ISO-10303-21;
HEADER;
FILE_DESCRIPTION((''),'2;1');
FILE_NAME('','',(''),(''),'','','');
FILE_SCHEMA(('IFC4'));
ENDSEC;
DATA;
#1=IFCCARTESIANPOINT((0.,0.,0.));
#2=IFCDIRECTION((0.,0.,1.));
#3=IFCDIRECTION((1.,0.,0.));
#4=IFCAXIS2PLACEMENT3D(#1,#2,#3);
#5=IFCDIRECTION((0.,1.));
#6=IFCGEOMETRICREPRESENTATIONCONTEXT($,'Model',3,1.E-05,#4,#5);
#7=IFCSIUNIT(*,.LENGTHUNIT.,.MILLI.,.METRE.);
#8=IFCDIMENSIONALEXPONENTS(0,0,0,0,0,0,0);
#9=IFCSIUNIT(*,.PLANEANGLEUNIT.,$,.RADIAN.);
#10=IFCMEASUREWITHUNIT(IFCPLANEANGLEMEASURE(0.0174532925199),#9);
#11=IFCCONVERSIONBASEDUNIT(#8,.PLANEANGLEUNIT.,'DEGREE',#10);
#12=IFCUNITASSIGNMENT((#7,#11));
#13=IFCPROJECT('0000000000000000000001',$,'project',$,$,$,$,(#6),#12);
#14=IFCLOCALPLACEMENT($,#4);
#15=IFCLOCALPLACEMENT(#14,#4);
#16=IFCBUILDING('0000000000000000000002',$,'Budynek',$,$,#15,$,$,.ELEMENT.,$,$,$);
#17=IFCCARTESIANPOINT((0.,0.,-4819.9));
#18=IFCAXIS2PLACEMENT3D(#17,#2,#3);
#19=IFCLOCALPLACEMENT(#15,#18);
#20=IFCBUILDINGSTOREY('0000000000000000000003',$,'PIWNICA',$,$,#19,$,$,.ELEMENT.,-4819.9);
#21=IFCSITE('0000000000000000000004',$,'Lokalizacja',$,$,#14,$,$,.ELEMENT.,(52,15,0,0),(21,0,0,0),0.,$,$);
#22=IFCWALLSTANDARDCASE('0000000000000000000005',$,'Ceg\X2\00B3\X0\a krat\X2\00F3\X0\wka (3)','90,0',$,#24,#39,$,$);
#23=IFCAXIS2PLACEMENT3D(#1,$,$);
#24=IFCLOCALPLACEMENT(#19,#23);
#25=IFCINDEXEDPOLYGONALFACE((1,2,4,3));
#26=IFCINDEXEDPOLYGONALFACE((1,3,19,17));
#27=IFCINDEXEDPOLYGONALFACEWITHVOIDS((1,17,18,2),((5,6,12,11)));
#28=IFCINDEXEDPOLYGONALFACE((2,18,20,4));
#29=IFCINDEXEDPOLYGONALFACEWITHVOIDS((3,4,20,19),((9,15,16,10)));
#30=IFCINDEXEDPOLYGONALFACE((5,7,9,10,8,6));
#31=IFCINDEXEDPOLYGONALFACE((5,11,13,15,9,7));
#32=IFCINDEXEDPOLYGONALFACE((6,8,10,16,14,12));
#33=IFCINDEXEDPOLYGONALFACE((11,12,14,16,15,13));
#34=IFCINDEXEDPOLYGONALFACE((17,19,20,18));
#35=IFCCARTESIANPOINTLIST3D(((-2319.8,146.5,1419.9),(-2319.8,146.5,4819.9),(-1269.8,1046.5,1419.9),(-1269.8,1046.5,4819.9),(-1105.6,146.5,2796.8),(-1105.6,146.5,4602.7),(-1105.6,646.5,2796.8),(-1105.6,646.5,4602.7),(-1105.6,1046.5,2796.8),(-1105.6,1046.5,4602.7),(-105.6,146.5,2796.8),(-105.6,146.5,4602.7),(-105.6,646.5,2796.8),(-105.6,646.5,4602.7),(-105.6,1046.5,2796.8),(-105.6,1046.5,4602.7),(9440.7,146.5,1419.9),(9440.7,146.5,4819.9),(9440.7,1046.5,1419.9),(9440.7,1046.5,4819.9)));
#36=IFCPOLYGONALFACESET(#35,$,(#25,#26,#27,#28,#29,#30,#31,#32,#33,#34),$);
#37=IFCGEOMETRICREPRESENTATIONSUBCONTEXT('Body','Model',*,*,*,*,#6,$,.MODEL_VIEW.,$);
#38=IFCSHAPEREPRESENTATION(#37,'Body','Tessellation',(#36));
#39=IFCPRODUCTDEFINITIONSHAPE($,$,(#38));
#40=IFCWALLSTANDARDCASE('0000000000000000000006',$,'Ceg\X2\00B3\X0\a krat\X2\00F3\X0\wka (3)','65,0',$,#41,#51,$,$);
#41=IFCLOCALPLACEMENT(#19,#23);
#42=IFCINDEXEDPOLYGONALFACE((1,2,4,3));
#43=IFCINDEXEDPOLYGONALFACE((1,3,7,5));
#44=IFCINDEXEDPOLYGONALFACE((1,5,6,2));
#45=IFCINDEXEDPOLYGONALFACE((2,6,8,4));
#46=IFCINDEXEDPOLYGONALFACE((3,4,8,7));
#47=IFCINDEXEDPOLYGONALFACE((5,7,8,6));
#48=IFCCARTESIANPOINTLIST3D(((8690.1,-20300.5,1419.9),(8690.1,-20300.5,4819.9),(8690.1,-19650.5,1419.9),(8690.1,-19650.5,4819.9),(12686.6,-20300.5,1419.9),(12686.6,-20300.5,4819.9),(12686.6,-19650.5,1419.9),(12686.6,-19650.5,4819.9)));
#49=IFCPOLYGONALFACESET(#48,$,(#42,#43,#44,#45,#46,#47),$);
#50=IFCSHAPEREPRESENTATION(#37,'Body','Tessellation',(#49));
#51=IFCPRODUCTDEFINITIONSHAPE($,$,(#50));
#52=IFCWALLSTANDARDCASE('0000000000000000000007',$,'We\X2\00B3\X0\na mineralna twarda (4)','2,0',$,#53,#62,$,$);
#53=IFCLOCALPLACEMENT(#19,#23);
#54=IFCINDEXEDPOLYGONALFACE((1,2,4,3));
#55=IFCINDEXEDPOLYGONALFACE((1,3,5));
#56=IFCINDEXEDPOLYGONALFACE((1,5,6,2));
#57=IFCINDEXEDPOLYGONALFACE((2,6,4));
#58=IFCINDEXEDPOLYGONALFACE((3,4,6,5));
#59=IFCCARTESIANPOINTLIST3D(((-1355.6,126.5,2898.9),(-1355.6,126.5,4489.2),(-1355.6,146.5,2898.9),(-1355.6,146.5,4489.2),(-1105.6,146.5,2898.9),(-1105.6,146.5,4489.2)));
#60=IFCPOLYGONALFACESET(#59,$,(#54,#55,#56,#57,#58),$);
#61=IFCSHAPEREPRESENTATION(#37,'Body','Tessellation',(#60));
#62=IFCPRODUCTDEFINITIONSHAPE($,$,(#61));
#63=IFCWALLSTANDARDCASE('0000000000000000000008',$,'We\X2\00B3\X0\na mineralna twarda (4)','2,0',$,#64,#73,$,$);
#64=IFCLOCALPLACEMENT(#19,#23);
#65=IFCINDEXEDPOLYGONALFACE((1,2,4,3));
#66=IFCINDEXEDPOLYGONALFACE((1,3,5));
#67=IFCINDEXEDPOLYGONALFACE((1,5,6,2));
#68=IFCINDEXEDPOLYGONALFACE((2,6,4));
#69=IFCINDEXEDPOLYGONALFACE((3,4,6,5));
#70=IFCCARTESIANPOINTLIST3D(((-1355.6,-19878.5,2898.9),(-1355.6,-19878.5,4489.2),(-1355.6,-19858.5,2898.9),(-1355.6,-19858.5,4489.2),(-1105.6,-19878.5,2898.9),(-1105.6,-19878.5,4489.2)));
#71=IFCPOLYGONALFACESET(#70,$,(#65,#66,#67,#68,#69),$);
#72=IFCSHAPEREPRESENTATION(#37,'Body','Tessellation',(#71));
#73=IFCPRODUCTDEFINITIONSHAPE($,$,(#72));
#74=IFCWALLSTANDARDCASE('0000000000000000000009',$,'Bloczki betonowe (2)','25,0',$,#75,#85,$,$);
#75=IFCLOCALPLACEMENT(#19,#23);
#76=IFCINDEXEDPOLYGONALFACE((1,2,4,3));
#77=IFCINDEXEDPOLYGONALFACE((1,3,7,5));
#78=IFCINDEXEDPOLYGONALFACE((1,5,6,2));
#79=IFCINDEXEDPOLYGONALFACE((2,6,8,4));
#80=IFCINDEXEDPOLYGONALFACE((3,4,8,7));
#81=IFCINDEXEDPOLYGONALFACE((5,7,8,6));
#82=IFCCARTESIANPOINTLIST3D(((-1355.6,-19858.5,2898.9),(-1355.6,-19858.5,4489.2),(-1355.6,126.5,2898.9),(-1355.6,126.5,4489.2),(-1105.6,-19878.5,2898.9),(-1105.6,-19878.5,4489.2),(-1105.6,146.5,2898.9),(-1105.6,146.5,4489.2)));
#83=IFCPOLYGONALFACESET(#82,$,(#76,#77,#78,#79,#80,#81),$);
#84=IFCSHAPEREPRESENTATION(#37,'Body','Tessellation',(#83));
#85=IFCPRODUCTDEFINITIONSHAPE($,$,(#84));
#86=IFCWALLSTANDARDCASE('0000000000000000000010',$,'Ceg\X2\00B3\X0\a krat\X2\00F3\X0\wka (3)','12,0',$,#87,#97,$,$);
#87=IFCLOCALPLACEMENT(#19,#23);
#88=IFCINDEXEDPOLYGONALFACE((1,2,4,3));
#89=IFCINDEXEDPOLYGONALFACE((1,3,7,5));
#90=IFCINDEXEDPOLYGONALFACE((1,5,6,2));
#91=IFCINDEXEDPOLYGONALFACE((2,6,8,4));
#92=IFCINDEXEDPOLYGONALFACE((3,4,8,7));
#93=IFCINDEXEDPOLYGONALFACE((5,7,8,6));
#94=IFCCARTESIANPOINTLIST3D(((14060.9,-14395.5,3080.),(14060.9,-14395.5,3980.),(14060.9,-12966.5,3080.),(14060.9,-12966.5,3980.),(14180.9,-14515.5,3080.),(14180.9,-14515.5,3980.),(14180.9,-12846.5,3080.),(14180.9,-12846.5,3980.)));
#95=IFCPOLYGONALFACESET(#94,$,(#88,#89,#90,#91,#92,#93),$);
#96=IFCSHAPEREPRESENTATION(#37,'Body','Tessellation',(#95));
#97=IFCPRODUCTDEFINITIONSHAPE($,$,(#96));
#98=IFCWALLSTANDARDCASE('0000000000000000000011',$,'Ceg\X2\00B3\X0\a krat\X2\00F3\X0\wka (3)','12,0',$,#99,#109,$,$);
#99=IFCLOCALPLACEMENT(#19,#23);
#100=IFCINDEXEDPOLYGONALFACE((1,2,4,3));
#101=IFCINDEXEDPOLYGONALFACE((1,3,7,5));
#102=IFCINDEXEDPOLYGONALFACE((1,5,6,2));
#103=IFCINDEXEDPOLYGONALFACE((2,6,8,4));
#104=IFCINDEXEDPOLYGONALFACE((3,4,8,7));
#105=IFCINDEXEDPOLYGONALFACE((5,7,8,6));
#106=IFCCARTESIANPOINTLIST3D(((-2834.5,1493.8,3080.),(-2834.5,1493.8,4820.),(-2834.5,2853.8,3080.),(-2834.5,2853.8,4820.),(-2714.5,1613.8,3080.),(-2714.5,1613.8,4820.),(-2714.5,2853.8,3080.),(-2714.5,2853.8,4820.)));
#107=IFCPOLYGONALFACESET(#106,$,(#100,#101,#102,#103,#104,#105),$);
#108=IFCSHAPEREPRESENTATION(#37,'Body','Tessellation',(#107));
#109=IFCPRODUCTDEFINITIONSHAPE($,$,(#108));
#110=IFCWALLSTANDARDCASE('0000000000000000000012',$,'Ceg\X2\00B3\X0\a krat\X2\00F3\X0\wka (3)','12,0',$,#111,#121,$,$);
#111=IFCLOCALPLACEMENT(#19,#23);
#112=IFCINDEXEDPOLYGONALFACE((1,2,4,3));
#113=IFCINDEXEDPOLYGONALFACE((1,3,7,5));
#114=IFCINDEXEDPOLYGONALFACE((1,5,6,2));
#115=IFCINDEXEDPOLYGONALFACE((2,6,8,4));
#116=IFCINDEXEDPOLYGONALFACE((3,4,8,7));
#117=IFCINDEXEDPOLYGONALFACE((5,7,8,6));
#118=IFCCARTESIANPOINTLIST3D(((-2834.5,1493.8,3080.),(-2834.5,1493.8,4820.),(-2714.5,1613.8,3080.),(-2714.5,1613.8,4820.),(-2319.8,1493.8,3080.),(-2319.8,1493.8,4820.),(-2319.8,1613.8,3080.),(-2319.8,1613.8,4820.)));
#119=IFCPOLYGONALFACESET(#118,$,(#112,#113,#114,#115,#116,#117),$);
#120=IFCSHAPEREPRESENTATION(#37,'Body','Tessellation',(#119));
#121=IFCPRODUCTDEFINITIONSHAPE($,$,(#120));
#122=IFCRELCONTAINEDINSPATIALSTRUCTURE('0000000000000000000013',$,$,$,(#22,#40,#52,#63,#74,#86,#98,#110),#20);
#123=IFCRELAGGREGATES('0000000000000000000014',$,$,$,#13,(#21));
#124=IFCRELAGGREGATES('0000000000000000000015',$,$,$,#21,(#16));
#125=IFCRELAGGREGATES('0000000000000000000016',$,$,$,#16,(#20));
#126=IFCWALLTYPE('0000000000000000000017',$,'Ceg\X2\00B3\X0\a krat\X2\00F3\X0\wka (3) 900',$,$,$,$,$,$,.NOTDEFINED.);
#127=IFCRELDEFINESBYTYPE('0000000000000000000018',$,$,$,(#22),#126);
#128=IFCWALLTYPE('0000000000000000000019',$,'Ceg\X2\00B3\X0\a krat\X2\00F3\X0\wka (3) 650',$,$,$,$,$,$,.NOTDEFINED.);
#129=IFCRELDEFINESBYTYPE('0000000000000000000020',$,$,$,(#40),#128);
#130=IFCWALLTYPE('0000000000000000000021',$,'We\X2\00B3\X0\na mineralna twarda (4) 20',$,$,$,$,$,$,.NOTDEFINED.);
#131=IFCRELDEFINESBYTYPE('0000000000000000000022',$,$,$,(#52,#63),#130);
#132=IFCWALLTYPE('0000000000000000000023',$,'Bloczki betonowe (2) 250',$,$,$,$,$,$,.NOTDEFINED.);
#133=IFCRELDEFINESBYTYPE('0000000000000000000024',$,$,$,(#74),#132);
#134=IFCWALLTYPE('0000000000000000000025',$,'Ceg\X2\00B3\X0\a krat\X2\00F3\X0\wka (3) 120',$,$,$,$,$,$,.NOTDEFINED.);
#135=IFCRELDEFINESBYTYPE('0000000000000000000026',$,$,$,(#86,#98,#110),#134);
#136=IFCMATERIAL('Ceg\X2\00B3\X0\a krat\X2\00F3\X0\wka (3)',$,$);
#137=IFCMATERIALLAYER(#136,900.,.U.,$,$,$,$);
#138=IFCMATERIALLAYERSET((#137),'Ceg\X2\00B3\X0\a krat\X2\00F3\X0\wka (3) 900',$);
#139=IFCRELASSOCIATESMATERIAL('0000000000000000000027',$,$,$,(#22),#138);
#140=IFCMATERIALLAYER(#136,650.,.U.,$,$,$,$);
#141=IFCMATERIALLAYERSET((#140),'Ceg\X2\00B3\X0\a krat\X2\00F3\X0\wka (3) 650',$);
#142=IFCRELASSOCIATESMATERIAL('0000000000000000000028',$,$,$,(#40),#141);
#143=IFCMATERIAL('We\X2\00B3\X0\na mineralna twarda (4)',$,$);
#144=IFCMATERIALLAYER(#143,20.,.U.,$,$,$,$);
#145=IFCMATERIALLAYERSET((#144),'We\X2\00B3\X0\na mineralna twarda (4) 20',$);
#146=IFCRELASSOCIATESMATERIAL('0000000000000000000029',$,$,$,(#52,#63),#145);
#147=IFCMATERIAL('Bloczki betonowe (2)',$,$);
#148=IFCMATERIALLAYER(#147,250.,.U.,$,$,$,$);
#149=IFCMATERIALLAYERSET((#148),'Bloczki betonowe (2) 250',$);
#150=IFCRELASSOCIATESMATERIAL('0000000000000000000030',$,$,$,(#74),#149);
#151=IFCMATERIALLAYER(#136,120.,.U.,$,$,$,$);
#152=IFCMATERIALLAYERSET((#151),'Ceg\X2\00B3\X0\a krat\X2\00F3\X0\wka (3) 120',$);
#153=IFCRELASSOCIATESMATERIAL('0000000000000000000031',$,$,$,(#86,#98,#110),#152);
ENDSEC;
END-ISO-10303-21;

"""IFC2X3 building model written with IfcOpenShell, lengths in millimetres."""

from ifc_helpers import new_model, entity, si_unit, converted_unit, direction, frame, origin_with_axes, origin_2d_with_axis, place, context, subcontext, project, spatial, polyline, rectangle, outline, extrude, material, layer, layer_set, layer_usage, type_object, element, save


model = new_model("IFC2X3")

# Units and contexts
model_context = context("Model", 3, precision=1e-05, world=origin_with_axes(), true_north=direction((0.0, 1.0)))
body_context = subcontext(model_context, "Body", "Model", "MODEL_VIEW")
ifc_project = project(units=[si_unit("LENGTHUNIT", "METRE", prefix="MILLI"), converted_unit("PLANEANGLEUNIT", "DEGREE", entity("IfcPlaneAngleMeasure", 0.0174532925199), si_unit("PLANEANGLEUNIT", "RADIAN"), dimensions=[0, 0, 0, 0, 0, 0, 0])], contexts=[model_context])

# Site, building, storey
site_placement = place(None, origin_with_axes())
site = spatial("IfcSite", under=ifc_project, at=site_placement, Name="Lokalizacja", CompositionType="ELEMENT", RefLatitude=(52, 15, 0, 0), RefLongitude=(21, 0, 0, 0), RefElevation=0.0)
building_placement = place(site_placement, origin_with_axes())
building = spatial("IfcBuilding", under=site, at=building_placement, Name="Budynek", CompositionType="ELEMENT")
storey_placement = place(building_placement, frame((0.0, 0.0, -4819.9), z_axis=(0.0, 0.0, 1.0), x_axis=(1.0, 0.0, 0.0)))
storey = spatial("IfcBuildingStorey", under=building, at=storey_placement, Name="PIWNICA", CompositionType="ELEMENT", Elevation=-4819.9)

# Shared definitions
ifc_material_1 = material(Name="Bloczki betonowe (2)")

# Shared definitions
ifc_material_2 = material(Name="Ceg³a kratówka (3)")

# Wall, opening
ifc_layer_1 = layer(ifc_material_2, 900.0, ventilated="UNKNOWN")
ifc_layer_set_1 = layer_set([ifc_layer_1], Name="Ceg³a kratówka (3) 900")
ifc_layer_usage_1 = layer_usage(ifc_layer_set_1, "AXIS2", "POSITIVE", -200.0)
wall_type_1 = type_object("IfcWallType", Name="Ceg³a kratówka (3) 900", PredefinedType="NOTDEFINED")
wall_1_placement = place(storey_placement, frame((9440.7, 846.5, 1419.9), z_axis=(0.0, 0.0, 1.0), x_axis=(-1.0, 0.0, 0.0)))
wall_1 = element("IfcWallStandardCase", 1, at=wall_1_placement, inside=storey, type_object=wall_type_1, material=ifc_layer_usage_1, Name="Ceg³a kratówka (3)", Description="90,0", context=body_context, shape_type="SweptSolid", body=[
    extrude(outline(polyline([(0.0, -200.0), (10710.5, -200.0), (11760.5, 700.0), (0.0, 700.0), (0.0, -200.0)])), origin_with_axes(), (0.0, 0.0, 1.0), 3400.0),
])
opening_1_placement = place(wall_1_placement, frame((10046.2, 0.0, 1376.9), z_axis=(0.0, 0.0, 1.0), x_axis=(1.0, 0.0, 0.0)))
element("IfcOpeningElement", 2, at=opening_1_placement, cuts=wall_1, context=body_context, shape_type="SweptSolid", body=[
    extrude(rectangle(XDim=1000.0, YDim=1805.9, at=origin_2d_with_axis()), frame((0.0, 200.0, 902.9), z_axis=(0.0, -1.0, 0.0), x_axis=(1.0, 0.0, 0.0)), (0.0, 0.0, -1.0), 900.0),
    extrude(rectangle(XDim=1000.0, YDim=1805.9, at=origin_2d_with_axis()), frame((0.0, 200.0, 902.9), z_axis=(0.0, 1.0, 0.0), x_axis=(1.0, 0.0, 0.0)), (0.0, 0.0, -1.0), 900.0),
])

# Walls
ifc_layer_2 = layer(ifc_material_2, 650.0, ventilated="UNKNOWN")
ifc_layer_set_2 = layer_set([ifc_layer_2], Name="Ceg³a kratówka (3) 650")
ifc_layer_usage_2 = layer_usage(ifc_layer_set_2, "AXIS2", "POSITIVE", 0.0)
wall_type_2 = type_object("IfcWallType", Name="Ceg³a kratówka (3) 650", PredefinedType="NOTDEFINED")
wall_2_placement = place(storey_placement, frame((12686.6, -19650.5, 1419.9), z_axis=(0.0, 0.0, 1.0), x_axis=(-1.0, 0.0, 0.0)))
element("IfcWallStandardCase", 3, at=wall_2_placement, inside=storey, type_object=wall_type_2, material=ifc_layer_usage_2, Name="Ceg³a kratówka (3)", Description="65,0", context=body_context, shape_type="SweptSolid", body=[
    extrude(outline(polyline([(0.0, 0.0), (3996.4, 0.0), (3996.4, 650.0), (0.0, 650.0), (0.0, 0.0)])), origin_with_axes(), (0.0, 0.0, 1.0), 3400.0),
])
ifc_material_3 = material(Name="We³na mineralna twarda (4)")
ifc_layer_3 = layer(ifc_material_3, 20.0, ventilated="UNKNOWN")
ifc_layer_set_3 = layer_set([ifc_layer_3], Name="We³na mineralna twarda (4) 20")
ifc_layer_usage_3 = layer_usage(ifc_layer_set_3, "AXIS2", "NEGATIVE", 0.0)
wall_type_3 = type_object("IfcWallType", Name="We³na mineralna twarda (4) 20", PredefinedType="NOTDEFINED")
wall_3_placement = place(storey_placement, frame((-1105.6, 126.5, 2898.9), z_axis=(0.0, 0.0, 1.0), x_axis=(-1.0, 0.0, 0.0)))
element("IfcWallStandardCase", 4, at=wall_3_placement, inside=storey, type_object=wall_type_3, material=ifc_layer_usage_3, Name="We³na mineralna twarda (4)", Description="2,0", context=body_context, shape_type="SweptSolid", body=[
    extrude(outline(polyline([(0.0, -20.0), (250.0, -20.0), (250.0, 0.0), (0.0, -20.0)])), origin_with_axes(), (0.0, 0.0, 1.0), 1590.3),
])
ifc_layer_usage_4 = layer_usage(ifc_layer_set_3, "AXIS2", "NEGATIVE", 0.0)
wall_4_placement = place(storey_placement, frame((-1105.6, -19878.5, 2898.9), z_axis=(0.0, 0.0, 1.0), x_axis=(-1.0, 0.0, 0.0)))
element("IfcWallStandardCase", 5, at=wall_4_placement, inside=storey, type_object=wall_type_3, material=ifc_layer_usage_4, Name="We³na mineralna twarda (4)", Description="2,0", context=body_context, shape_type="SweptSolid", body=[
    extrude(outline(polyline([(250.0, -20.0), (250.0, 0.0), (0.0, 0.0), (250.0, -20.0)])), origin_with_axes(), (0.0, 0.0, 1.0), 1590.3),
])
ifc_layer_4 = layer(ifc_material_1, 250.0, ventilated="UNKNOWN")
ifc_layer_set_4 = layer_set([ifc_layer_4], Name="Bloczki betonowe (2) 250")
ifc_layer_usage_5 = layer_usage(ifc_layer_set_4, "AXIS2", "POSITIVE", 0.0)
wall_type_4 = type_object("IfcWallType", Name="Bloczki betonowe (2) 250", PredefinedType="NOTDEFINED")
wall_5_placement = place(storey_placement, frame((-1105.6, -19878.5, 2898.9), z_axis=(0.0, 0.0, 1.0), x_axis=(0.0, 1.0, 0.0)))
element("IfcWallStandardCase", 6, at=wall_5_placement, inside=storey, type_object=wall_type_4, material=ifc_layer_usage_5, Name="Bloczki betonowe (2)", Description="25,0", context=body_context, shape_type="SweptSolid", body=[
    extrude(outline(polyline([(0.0, 0.0), (20025.0, 0.0), (20005.0, 250.0), (20.0, 250.0), (0.0, 0.0)])), origin_with_axes(), (0.0, 0.0, 1.0), 1590.3),
])
ifc_layer_5 = layer(ifc_material_2, 120.0, ventilated="UNKNOWN")
ifc_layer_set_5 = layer_set([ifc_layer_5], Name="Ceg³a kratówka (3) 120")
ifc_layer_usage_6 = layer_usage(ifc_layer_set_5, "AXIS2", "NEGATIVE", 0.0)
wall_type_5 = type_object("IfcWallType", Name="Ceg³a kratówka (3) 120", PredefinedType="NOTDEFINED")
wall_6_placement = place(storey_placement, frame((14060.9, -14395.5, 3080.0), z_axis=(0.0, 0.0, 1.0), x_axis=(0.0, 1.0, 0.0)))
element("IfcWallStandardCase", 7, at=wall_6_placement, inside=storey, type_object=wall_type_5, material=ifc_layer_usage_6, Name="Ceg³a kratówka (3)", Description="12,0", context=body_context, shape_type="SweptSolid", body=[
    extrude(outline(polyline([(-120.0, -120.0), (1549.0, -120.0), (1429.0, 0.0), (0.0, 0.0), (-120.0, -120.0)])), origin_with_axes(), (0.0, 0.0, 1.0), 900.0),
])
ifc_layer_usage_7 = layer_usage(ifc_layer_set_5, "AXIS2", "POSITIVE", 0.0)
wall_7_placement = place(storey_placement, frame((-2714.5, 1613.8, 3080.0), z_axis=(0.0, 0.0, 1.0), x_axis=(0.0, 1.0, 0.0)))
element("IfcWallStandardCase", 8, at=wall_7_placement, inside=storey, type_object=wall_type_5, material=ifc_layer_usage_7, Name="Ceg³a kratówka (3)", Description="12,0", context=body_context, shape_type="SweptSolid", body=[
    extrude(outline(polyline([(0.0, 0.0), (1240.0, 0.0), (1240.0, 120.0), (-120.0, 120.0), (0.0, 0.0)])), origin_with_axes(), (0.0, 0.0, 1.0), 1740.0),
])
ifc_layer_usage_8 = layer_usage(ifc_layer_set_5, "AXIS2", "NEGATIVE", 0.0)
wall_8_placement = place(storey_placement, frame((-2714.5, 1613.8, 3080.0), z_axis=(0.0, 0.0, 1.0), x_axis=(1.0, 0.0, 0.0)))
element("IfcWallStandardCase", 9, at=wall_8_placement, inside=storey, type_object=wall_type_5, material=ifc_layer_usage_8, Name="Ceg³a kratówka (3)", Description="12,0", context=body_context, shape_type="SweptSolid", body=[
    extrude(outline(polyline([(-120.0, -120.0), (394.6, -120.0), (394.6, 0.0), (0.0, 0.0), (-120.0, -120.0)])), origin_with_axes(), (0.0, 0.0, 1.0), 1740.0),
])

save(model, "model.ifc")
